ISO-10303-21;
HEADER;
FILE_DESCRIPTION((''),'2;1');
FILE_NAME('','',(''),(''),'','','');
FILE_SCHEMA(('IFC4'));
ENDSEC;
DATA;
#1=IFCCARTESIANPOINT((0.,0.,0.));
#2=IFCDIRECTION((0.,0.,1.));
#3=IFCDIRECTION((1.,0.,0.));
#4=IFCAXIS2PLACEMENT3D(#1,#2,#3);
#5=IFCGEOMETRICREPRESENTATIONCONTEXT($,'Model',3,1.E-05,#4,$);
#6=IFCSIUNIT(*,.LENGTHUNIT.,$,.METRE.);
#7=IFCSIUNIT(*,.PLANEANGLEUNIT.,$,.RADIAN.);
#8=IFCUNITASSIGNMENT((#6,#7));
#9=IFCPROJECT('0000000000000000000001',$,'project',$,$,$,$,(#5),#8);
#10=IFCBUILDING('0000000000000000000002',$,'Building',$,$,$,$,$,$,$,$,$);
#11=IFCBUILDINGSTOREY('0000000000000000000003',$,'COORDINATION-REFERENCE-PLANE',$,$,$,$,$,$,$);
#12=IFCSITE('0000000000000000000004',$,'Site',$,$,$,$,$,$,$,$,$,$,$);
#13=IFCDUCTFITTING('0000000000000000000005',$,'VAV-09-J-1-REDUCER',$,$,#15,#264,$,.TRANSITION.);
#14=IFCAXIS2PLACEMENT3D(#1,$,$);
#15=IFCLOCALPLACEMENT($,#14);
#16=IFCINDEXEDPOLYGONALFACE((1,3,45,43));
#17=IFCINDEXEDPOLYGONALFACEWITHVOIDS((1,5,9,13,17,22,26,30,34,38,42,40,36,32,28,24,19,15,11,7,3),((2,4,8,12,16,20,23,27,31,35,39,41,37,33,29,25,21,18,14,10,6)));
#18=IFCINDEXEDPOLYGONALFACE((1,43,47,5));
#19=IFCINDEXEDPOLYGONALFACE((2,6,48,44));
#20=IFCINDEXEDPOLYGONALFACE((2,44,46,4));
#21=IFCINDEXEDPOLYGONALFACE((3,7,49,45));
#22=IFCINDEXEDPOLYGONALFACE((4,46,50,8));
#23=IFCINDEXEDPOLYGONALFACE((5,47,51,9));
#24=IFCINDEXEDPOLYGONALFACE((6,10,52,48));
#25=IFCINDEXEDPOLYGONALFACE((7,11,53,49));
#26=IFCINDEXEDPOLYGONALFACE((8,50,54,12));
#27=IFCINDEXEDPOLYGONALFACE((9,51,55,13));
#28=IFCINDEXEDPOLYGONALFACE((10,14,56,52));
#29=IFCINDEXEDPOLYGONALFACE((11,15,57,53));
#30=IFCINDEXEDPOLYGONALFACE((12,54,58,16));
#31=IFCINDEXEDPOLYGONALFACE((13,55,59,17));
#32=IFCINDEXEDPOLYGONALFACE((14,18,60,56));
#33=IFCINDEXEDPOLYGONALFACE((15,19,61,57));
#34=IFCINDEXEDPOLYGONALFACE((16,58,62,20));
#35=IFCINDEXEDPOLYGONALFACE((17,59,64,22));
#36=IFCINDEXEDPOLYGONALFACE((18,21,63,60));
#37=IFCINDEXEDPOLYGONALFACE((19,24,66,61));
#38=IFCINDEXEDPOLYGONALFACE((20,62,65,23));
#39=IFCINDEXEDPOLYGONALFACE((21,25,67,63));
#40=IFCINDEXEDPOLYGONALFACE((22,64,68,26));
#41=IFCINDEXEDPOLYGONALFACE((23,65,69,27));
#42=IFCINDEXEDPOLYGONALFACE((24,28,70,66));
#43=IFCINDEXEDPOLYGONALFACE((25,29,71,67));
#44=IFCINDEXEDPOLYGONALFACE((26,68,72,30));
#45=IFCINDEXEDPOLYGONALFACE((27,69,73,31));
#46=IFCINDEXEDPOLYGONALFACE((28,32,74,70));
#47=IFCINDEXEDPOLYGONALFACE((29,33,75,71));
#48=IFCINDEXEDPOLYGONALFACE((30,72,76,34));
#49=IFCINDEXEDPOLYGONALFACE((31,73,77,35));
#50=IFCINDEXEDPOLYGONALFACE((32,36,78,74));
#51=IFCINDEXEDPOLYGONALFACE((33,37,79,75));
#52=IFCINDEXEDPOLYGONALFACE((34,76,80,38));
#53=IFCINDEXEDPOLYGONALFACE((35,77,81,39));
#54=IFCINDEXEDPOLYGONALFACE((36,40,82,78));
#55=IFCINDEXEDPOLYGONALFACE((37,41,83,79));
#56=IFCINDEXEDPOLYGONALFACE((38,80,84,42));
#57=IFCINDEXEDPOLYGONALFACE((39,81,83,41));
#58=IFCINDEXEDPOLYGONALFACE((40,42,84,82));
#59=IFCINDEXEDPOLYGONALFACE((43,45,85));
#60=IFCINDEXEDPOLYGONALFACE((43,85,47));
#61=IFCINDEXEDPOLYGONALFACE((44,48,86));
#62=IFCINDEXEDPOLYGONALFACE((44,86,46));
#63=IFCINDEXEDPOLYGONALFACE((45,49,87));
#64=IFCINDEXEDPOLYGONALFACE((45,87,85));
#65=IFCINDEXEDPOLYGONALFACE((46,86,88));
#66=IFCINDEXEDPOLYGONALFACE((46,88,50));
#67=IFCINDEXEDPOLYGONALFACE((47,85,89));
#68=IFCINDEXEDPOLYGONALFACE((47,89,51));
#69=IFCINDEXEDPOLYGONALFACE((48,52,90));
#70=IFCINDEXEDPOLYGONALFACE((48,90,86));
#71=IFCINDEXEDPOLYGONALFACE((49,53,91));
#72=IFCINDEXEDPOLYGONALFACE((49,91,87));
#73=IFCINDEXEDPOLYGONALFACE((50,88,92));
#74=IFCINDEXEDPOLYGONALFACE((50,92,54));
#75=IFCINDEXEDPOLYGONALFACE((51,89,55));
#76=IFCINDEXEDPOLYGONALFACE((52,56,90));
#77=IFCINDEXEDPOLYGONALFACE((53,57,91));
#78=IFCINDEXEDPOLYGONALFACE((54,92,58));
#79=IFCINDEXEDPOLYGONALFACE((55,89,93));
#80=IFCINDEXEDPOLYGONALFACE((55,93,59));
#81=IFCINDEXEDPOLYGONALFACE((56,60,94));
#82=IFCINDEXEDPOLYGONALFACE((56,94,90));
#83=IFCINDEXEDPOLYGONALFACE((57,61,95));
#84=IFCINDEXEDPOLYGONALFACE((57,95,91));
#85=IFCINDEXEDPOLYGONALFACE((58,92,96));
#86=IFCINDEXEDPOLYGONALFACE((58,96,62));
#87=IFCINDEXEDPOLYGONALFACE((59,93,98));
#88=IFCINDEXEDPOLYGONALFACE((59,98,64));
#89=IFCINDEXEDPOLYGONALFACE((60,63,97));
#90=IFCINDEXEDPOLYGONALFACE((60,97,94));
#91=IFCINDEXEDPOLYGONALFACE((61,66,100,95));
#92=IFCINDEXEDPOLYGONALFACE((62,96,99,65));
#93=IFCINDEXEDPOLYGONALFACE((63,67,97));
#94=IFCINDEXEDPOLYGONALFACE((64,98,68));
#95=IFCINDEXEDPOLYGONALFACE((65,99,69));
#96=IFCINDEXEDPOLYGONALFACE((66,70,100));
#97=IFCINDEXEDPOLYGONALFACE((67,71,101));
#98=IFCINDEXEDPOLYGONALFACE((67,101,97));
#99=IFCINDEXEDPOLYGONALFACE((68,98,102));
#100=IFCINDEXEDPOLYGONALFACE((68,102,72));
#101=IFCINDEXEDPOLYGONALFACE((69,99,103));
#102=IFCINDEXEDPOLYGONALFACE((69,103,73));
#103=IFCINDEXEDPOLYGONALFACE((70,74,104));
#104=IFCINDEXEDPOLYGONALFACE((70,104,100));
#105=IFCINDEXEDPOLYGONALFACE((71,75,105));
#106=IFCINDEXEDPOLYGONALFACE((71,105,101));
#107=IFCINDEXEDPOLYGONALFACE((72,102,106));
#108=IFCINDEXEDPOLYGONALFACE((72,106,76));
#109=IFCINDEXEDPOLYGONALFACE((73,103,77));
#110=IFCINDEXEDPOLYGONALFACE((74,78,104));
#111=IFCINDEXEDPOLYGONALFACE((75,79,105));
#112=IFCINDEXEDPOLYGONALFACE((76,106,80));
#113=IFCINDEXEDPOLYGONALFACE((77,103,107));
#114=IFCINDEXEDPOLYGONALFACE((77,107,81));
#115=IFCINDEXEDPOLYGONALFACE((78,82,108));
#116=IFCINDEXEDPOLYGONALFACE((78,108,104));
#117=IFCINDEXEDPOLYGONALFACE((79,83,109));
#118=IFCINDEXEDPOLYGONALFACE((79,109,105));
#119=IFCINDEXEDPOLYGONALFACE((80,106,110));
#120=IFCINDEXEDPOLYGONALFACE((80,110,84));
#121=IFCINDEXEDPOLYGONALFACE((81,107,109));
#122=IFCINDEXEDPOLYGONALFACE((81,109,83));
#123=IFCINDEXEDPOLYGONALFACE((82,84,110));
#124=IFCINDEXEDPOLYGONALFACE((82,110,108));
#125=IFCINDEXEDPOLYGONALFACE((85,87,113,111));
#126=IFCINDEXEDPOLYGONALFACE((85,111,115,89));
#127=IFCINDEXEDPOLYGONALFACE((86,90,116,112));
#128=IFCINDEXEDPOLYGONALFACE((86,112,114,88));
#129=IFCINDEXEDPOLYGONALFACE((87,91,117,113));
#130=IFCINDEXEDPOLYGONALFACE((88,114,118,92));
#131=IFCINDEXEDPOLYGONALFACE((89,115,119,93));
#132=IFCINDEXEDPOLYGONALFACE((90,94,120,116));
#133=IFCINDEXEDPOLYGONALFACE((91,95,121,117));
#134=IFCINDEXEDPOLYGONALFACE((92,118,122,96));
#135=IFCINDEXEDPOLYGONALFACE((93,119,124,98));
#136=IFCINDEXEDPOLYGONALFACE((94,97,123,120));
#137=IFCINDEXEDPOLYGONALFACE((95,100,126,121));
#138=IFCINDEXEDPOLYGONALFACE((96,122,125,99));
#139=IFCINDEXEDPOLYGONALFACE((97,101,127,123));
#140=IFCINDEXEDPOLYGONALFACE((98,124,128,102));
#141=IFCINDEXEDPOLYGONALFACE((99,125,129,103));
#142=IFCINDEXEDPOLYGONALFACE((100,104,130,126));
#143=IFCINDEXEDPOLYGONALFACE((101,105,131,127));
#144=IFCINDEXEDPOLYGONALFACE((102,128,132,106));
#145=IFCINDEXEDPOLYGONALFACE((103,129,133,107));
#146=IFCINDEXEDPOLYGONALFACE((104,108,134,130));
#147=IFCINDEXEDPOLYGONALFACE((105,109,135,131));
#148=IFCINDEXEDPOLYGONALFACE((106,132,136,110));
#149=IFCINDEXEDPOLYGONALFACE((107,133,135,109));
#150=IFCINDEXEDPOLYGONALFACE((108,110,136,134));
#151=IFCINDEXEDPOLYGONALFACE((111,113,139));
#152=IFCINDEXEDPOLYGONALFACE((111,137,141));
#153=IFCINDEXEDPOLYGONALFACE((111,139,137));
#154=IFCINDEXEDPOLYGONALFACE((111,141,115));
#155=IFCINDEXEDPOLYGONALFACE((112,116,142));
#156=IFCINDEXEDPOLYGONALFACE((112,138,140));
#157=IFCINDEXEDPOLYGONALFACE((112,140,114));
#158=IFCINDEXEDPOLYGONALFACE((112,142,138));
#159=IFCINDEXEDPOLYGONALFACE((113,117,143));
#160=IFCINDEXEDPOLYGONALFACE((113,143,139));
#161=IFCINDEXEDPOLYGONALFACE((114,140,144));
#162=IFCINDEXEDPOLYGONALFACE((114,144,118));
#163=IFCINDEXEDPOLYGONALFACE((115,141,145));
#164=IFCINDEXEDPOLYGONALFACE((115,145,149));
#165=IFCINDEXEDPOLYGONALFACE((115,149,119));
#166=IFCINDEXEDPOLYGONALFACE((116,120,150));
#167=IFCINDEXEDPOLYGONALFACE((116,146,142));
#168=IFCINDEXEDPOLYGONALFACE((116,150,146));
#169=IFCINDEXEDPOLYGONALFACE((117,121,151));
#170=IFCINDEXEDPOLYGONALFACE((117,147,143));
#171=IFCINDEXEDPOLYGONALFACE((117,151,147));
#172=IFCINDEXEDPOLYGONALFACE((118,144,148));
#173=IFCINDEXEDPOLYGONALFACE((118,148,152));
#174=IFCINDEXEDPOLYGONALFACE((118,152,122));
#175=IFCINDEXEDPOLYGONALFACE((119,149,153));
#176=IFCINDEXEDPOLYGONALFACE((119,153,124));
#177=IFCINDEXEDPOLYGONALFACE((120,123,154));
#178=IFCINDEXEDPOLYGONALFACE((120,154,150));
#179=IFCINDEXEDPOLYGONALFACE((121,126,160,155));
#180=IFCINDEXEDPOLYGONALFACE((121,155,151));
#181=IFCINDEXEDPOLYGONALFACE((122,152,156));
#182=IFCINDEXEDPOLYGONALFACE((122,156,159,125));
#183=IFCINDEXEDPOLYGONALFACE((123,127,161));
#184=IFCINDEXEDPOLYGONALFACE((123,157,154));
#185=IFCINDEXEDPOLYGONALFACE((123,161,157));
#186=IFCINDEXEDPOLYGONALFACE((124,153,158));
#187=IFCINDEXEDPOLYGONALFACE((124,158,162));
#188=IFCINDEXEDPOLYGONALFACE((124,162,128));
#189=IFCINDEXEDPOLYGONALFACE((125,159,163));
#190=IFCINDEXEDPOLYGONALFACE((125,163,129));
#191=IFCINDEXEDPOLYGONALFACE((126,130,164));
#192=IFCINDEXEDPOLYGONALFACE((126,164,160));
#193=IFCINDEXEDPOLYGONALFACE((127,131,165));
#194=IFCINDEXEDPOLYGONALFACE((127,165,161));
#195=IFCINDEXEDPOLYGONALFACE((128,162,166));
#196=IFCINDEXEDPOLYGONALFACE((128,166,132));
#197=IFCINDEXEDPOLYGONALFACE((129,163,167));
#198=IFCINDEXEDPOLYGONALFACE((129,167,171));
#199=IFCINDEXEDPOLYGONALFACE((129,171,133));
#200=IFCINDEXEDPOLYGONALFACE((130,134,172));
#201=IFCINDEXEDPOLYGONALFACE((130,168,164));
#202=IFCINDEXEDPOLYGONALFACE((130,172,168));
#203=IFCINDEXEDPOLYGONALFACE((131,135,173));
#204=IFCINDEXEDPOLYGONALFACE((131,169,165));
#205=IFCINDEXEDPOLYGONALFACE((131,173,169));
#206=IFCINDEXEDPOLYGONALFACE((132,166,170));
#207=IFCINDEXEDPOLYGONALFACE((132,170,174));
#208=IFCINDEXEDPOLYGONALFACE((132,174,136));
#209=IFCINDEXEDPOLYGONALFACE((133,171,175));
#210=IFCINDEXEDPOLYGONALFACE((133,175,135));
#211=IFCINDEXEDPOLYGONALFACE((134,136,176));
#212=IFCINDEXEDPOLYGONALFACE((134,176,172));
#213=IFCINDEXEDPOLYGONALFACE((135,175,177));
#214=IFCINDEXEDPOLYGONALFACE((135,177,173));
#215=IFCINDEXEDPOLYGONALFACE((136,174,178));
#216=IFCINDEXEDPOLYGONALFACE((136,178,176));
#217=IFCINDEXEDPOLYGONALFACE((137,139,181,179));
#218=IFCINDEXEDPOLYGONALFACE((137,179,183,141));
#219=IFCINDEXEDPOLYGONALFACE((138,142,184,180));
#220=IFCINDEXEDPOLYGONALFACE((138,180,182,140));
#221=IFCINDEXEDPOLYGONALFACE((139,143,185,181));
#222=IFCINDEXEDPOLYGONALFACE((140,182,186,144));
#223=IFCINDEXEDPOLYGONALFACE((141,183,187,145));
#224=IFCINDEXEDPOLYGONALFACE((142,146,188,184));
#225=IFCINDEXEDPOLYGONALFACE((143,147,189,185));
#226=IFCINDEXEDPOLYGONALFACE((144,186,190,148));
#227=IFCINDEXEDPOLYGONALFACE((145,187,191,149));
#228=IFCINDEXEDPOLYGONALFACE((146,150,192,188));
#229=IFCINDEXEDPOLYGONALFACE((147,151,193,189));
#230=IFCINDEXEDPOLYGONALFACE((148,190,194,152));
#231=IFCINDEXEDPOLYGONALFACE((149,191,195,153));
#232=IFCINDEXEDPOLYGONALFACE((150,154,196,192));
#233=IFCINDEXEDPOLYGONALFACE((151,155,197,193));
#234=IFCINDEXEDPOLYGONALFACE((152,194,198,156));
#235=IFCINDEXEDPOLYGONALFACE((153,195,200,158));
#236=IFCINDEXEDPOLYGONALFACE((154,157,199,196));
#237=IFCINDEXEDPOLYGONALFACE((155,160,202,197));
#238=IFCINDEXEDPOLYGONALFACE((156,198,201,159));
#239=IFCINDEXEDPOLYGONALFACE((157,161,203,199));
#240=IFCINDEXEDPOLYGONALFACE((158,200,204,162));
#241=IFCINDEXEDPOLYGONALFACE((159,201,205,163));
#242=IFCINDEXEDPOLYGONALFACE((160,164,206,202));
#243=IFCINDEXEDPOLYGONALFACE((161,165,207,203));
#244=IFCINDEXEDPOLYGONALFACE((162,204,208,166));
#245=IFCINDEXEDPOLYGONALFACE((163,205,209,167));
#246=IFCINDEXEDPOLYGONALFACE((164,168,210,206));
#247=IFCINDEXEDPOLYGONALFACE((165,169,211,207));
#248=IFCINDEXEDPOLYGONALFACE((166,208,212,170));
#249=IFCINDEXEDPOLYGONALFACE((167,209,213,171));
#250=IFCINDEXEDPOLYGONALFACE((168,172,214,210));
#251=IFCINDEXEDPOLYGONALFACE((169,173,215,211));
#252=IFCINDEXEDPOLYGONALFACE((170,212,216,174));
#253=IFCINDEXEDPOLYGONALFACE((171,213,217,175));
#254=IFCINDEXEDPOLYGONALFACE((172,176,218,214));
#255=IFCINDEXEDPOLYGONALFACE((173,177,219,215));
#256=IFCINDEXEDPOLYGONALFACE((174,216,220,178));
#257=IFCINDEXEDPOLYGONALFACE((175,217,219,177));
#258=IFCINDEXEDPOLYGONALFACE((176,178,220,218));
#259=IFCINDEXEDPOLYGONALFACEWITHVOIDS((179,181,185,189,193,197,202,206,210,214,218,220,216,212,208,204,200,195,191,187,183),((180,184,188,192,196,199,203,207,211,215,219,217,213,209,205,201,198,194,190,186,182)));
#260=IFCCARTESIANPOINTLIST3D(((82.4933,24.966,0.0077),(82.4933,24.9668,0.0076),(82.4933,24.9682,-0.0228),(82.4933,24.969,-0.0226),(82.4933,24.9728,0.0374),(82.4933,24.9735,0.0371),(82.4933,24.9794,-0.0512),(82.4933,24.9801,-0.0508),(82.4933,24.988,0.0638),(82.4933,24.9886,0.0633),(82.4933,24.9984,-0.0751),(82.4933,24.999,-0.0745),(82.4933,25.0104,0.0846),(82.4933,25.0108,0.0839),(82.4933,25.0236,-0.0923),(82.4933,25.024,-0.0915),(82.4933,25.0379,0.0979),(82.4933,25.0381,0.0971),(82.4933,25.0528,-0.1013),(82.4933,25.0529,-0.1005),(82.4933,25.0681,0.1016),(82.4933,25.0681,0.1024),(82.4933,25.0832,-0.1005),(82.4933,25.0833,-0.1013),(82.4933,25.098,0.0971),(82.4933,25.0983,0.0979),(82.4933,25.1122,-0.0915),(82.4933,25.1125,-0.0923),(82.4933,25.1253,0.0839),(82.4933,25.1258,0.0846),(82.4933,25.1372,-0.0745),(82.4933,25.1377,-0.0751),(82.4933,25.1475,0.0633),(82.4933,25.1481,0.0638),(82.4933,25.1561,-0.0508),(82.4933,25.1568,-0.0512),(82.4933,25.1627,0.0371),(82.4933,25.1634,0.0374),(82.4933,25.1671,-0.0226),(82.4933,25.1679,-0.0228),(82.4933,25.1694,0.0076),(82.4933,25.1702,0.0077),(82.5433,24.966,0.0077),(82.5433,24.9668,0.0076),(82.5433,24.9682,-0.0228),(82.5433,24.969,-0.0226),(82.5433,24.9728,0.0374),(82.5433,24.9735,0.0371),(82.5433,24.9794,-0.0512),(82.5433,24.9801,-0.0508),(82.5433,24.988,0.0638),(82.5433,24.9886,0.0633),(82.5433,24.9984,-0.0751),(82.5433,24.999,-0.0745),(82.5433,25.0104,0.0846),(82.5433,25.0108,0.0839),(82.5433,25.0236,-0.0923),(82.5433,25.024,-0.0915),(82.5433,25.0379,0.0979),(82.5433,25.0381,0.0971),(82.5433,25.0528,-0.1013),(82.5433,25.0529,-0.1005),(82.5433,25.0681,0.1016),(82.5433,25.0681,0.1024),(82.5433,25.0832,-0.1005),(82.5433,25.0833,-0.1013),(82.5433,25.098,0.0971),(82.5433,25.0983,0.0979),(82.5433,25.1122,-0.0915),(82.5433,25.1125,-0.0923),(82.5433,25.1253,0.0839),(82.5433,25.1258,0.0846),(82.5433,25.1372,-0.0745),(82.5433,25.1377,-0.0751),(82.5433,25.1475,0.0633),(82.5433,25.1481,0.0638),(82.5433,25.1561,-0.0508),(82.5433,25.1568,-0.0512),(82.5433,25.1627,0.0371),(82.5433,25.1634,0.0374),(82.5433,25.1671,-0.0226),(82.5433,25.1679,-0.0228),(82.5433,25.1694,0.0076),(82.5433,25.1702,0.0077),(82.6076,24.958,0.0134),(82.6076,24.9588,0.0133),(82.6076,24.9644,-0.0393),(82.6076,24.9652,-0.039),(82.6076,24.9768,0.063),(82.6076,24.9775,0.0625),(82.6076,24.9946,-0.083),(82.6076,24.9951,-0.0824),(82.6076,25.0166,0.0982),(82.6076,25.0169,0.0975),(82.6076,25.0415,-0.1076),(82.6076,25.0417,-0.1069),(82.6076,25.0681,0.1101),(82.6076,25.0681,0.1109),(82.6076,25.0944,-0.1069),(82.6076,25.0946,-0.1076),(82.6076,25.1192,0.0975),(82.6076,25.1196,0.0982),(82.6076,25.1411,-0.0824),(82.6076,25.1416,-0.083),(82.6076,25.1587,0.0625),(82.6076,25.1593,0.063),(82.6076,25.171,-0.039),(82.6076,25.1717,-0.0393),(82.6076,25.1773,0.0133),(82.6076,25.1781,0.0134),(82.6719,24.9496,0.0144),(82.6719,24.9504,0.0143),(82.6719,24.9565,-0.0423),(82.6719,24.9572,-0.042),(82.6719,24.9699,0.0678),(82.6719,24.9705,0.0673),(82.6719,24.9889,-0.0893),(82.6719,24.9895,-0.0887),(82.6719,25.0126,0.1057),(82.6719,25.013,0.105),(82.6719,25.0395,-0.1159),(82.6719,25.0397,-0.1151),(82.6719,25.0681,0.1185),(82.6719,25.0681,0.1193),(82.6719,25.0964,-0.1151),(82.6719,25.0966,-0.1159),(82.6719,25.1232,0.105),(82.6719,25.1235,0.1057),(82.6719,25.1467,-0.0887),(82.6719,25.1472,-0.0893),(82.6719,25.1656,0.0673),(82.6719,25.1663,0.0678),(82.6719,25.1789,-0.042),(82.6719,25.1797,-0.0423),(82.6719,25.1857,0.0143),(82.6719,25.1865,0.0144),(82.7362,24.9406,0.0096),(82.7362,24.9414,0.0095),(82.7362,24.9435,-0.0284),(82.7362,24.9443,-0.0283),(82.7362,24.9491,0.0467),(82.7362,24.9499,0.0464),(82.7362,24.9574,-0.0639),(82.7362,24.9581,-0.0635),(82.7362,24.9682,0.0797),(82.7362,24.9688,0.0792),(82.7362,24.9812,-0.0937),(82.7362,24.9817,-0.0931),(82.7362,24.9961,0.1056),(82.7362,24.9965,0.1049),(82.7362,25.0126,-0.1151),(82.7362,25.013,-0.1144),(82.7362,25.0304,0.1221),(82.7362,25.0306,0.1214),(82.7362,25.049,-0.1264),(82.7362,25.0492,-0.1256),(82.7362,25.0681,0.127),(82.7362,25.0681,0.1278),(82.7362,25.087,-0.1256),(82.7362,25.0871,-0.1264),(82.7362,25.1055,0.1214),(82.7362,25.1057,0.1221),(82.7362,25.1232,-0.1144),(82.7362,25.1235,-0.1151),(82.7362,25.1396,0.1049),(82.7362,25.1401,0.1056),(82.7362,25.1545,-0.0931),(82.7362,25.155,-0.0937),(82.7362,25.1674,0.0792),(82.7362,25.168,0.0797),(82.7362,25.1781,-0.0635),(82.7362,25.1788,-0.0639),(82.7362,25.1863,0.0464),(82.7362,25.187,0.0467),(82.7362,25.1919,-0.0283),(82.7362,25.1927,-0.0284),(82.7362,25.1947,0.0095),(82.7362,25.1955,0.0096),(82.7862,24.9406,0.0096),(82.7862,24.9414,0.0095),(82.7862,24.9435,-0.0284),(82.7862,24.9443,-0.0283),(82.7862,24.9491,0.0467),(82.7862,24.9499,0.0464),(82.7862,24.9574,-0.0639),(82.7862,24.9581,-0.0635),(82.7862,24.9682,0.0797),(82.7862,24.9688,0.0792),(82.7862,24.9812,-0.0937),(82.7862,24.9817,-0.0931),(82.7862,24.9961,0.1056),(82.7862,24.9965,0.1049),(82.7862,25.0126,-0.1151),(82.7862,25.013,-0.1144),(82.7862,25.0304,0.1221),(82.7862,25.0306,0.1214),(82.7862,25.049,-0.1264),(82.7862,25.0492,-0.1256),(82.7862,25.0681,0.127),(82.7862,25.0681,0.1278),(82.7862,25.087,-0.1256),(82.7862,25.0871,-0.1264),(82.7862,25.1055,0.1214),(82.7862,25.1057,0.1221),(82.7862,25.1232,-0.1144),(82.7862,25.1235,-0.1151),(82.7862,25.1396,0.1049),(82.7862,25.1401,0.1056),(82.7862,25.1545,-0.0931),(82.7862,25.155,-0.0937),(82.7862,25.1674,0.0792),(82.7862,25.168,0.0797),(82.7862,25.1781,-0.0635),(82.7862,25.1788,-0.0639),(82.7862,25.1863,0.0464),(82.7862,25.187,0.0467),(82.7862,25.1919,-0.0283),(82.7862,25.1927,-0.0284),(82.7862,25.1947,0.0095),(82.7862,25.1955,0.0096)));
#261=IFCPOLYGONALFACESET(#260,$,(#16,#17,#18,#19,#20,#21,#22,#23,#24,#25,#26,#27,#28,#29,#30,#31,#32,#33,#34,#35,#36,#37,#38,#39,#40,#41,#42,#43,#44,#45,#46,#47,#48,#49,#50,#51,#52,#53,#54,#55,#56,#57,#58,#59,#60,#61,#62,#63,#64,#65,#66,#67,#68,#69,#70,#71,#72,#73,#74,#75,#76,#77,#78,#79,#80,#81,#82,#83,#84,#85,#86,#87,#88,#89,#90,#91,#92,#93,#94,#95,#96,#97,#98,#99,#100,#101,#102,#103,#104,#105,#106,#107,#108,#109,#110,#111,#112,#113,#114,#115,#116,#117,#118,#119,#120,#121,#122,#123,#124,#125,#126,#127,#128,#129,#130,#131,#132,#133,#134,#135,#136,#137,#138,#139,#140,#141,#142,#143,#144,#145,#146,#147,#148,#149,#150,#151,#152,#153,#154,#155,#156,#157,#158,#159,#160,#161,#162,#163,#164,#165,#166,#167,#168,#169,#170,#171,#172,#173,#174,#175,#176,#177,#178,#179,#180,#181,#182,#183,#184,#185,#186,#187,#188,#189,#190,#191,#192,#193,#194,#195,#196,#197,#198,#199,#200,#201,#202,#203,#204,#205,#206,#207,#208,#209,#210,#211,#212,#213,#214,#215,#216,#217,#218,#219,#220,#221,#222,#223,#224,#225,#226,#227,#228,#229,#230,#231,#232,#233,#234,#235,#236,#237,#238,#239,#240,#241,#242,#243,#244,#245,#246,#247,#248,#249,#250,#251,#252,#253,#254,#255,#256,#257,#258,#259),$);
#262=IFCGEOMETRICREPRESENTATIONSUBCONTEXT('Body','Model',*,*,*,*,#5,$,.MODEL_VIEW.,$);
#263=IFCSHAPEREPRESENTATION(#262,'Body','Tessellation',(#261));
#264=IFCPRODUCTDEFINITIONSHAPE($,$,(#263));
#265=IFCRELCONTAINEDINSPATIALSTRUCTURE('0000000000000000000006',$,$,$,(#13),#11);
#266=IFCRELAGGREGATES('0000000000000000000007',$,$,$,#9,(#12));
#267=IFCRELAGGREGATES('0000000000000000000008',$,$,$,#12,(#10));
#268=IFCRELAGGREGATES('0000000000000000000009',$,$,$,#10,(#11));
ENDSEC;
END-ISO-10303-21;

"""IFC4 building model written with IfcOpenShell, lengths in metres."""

from ifc_helpers import new_model, entity, si_unit, frame, origin_with_axes, place, context, subcontext, project, spatial, element, save


model = new_model("IFC4")

# Units and contexts
model_context_1 = context("Model", 3, precision=1e-05, world=origin_with_axes())
body_context_1 = subcontext(model_context_1, "Body", "Model", "MODEL_VIEW")
ifc_project = project(units=[si_unit("LENGTHUNIT", "METRE"), si_unit("PLANEANGLEUNIT", "RADIAN")], contexts=[model_context_1])

# Site, building, storey
site = spatial("IfcSite", under=ifc_project, Name="Site")
building = spatial("IfcBuilding", under=site, Name="Building")
storey = spatial("IfcBuildingStorey", under=building, Name="COORDINATION-REFERENCE-PLANE")

# Duct fitting
for number, where, z_axis, x_axis, name in (
    (1, (82.7862, 25.0681, 0.0), (0.0, -1.0, 0.0), (0.0, 0.0, 1.0), "VAV-09-J-1-REDUCER"),
):
    element("IfcDuctFitting", number, at=place(None, frame(where, z_axis=z_axis, x_axis=x_axis)), inside=storey, Name=name, PredefinedType="TRANSITION", context=body_context_1, shape_type="SweptSolid", body=[
        entity("IfcRevolvedAreaSolid", entity("IfcArbitraryClosedProfileDef", "AREA", None, entity("IfcPolyline", [entity("IfcCartesianPoint", [0.1278, 0.0]), entity("IfcCartesianPoint", [0.1278, 0.05]), entity("IfcCartesianPoint", [0.1024, 0.2429]), entity("IfcCartesianPoint", [0.1024, 0.2929]), entity("IfcCartesianPoint", [0.1016, 0.2929]), entity("IfcCartesianPoint", [0.1016, 0.2429]), entity("IfcCartesianPoint", [0.127, 0.05]), entity("IfcCartesianPoint", [0.127, 0.0]), entity("IfcCartesianPoint", [0.1278, 0.0])])), entity("IfcAxis2Placement3D", entity("IfcCartesianPoint", [0.0, 0.0, 0.0])), entity("IfcAxis1Placement", entity("IfcCartesianPoint", [0.0, 0.0, 0.0]), entity("IfcDirection", [0.0, 1.0, 0.0])), 6.283185),
    ])

save(model, "model.ifc")
